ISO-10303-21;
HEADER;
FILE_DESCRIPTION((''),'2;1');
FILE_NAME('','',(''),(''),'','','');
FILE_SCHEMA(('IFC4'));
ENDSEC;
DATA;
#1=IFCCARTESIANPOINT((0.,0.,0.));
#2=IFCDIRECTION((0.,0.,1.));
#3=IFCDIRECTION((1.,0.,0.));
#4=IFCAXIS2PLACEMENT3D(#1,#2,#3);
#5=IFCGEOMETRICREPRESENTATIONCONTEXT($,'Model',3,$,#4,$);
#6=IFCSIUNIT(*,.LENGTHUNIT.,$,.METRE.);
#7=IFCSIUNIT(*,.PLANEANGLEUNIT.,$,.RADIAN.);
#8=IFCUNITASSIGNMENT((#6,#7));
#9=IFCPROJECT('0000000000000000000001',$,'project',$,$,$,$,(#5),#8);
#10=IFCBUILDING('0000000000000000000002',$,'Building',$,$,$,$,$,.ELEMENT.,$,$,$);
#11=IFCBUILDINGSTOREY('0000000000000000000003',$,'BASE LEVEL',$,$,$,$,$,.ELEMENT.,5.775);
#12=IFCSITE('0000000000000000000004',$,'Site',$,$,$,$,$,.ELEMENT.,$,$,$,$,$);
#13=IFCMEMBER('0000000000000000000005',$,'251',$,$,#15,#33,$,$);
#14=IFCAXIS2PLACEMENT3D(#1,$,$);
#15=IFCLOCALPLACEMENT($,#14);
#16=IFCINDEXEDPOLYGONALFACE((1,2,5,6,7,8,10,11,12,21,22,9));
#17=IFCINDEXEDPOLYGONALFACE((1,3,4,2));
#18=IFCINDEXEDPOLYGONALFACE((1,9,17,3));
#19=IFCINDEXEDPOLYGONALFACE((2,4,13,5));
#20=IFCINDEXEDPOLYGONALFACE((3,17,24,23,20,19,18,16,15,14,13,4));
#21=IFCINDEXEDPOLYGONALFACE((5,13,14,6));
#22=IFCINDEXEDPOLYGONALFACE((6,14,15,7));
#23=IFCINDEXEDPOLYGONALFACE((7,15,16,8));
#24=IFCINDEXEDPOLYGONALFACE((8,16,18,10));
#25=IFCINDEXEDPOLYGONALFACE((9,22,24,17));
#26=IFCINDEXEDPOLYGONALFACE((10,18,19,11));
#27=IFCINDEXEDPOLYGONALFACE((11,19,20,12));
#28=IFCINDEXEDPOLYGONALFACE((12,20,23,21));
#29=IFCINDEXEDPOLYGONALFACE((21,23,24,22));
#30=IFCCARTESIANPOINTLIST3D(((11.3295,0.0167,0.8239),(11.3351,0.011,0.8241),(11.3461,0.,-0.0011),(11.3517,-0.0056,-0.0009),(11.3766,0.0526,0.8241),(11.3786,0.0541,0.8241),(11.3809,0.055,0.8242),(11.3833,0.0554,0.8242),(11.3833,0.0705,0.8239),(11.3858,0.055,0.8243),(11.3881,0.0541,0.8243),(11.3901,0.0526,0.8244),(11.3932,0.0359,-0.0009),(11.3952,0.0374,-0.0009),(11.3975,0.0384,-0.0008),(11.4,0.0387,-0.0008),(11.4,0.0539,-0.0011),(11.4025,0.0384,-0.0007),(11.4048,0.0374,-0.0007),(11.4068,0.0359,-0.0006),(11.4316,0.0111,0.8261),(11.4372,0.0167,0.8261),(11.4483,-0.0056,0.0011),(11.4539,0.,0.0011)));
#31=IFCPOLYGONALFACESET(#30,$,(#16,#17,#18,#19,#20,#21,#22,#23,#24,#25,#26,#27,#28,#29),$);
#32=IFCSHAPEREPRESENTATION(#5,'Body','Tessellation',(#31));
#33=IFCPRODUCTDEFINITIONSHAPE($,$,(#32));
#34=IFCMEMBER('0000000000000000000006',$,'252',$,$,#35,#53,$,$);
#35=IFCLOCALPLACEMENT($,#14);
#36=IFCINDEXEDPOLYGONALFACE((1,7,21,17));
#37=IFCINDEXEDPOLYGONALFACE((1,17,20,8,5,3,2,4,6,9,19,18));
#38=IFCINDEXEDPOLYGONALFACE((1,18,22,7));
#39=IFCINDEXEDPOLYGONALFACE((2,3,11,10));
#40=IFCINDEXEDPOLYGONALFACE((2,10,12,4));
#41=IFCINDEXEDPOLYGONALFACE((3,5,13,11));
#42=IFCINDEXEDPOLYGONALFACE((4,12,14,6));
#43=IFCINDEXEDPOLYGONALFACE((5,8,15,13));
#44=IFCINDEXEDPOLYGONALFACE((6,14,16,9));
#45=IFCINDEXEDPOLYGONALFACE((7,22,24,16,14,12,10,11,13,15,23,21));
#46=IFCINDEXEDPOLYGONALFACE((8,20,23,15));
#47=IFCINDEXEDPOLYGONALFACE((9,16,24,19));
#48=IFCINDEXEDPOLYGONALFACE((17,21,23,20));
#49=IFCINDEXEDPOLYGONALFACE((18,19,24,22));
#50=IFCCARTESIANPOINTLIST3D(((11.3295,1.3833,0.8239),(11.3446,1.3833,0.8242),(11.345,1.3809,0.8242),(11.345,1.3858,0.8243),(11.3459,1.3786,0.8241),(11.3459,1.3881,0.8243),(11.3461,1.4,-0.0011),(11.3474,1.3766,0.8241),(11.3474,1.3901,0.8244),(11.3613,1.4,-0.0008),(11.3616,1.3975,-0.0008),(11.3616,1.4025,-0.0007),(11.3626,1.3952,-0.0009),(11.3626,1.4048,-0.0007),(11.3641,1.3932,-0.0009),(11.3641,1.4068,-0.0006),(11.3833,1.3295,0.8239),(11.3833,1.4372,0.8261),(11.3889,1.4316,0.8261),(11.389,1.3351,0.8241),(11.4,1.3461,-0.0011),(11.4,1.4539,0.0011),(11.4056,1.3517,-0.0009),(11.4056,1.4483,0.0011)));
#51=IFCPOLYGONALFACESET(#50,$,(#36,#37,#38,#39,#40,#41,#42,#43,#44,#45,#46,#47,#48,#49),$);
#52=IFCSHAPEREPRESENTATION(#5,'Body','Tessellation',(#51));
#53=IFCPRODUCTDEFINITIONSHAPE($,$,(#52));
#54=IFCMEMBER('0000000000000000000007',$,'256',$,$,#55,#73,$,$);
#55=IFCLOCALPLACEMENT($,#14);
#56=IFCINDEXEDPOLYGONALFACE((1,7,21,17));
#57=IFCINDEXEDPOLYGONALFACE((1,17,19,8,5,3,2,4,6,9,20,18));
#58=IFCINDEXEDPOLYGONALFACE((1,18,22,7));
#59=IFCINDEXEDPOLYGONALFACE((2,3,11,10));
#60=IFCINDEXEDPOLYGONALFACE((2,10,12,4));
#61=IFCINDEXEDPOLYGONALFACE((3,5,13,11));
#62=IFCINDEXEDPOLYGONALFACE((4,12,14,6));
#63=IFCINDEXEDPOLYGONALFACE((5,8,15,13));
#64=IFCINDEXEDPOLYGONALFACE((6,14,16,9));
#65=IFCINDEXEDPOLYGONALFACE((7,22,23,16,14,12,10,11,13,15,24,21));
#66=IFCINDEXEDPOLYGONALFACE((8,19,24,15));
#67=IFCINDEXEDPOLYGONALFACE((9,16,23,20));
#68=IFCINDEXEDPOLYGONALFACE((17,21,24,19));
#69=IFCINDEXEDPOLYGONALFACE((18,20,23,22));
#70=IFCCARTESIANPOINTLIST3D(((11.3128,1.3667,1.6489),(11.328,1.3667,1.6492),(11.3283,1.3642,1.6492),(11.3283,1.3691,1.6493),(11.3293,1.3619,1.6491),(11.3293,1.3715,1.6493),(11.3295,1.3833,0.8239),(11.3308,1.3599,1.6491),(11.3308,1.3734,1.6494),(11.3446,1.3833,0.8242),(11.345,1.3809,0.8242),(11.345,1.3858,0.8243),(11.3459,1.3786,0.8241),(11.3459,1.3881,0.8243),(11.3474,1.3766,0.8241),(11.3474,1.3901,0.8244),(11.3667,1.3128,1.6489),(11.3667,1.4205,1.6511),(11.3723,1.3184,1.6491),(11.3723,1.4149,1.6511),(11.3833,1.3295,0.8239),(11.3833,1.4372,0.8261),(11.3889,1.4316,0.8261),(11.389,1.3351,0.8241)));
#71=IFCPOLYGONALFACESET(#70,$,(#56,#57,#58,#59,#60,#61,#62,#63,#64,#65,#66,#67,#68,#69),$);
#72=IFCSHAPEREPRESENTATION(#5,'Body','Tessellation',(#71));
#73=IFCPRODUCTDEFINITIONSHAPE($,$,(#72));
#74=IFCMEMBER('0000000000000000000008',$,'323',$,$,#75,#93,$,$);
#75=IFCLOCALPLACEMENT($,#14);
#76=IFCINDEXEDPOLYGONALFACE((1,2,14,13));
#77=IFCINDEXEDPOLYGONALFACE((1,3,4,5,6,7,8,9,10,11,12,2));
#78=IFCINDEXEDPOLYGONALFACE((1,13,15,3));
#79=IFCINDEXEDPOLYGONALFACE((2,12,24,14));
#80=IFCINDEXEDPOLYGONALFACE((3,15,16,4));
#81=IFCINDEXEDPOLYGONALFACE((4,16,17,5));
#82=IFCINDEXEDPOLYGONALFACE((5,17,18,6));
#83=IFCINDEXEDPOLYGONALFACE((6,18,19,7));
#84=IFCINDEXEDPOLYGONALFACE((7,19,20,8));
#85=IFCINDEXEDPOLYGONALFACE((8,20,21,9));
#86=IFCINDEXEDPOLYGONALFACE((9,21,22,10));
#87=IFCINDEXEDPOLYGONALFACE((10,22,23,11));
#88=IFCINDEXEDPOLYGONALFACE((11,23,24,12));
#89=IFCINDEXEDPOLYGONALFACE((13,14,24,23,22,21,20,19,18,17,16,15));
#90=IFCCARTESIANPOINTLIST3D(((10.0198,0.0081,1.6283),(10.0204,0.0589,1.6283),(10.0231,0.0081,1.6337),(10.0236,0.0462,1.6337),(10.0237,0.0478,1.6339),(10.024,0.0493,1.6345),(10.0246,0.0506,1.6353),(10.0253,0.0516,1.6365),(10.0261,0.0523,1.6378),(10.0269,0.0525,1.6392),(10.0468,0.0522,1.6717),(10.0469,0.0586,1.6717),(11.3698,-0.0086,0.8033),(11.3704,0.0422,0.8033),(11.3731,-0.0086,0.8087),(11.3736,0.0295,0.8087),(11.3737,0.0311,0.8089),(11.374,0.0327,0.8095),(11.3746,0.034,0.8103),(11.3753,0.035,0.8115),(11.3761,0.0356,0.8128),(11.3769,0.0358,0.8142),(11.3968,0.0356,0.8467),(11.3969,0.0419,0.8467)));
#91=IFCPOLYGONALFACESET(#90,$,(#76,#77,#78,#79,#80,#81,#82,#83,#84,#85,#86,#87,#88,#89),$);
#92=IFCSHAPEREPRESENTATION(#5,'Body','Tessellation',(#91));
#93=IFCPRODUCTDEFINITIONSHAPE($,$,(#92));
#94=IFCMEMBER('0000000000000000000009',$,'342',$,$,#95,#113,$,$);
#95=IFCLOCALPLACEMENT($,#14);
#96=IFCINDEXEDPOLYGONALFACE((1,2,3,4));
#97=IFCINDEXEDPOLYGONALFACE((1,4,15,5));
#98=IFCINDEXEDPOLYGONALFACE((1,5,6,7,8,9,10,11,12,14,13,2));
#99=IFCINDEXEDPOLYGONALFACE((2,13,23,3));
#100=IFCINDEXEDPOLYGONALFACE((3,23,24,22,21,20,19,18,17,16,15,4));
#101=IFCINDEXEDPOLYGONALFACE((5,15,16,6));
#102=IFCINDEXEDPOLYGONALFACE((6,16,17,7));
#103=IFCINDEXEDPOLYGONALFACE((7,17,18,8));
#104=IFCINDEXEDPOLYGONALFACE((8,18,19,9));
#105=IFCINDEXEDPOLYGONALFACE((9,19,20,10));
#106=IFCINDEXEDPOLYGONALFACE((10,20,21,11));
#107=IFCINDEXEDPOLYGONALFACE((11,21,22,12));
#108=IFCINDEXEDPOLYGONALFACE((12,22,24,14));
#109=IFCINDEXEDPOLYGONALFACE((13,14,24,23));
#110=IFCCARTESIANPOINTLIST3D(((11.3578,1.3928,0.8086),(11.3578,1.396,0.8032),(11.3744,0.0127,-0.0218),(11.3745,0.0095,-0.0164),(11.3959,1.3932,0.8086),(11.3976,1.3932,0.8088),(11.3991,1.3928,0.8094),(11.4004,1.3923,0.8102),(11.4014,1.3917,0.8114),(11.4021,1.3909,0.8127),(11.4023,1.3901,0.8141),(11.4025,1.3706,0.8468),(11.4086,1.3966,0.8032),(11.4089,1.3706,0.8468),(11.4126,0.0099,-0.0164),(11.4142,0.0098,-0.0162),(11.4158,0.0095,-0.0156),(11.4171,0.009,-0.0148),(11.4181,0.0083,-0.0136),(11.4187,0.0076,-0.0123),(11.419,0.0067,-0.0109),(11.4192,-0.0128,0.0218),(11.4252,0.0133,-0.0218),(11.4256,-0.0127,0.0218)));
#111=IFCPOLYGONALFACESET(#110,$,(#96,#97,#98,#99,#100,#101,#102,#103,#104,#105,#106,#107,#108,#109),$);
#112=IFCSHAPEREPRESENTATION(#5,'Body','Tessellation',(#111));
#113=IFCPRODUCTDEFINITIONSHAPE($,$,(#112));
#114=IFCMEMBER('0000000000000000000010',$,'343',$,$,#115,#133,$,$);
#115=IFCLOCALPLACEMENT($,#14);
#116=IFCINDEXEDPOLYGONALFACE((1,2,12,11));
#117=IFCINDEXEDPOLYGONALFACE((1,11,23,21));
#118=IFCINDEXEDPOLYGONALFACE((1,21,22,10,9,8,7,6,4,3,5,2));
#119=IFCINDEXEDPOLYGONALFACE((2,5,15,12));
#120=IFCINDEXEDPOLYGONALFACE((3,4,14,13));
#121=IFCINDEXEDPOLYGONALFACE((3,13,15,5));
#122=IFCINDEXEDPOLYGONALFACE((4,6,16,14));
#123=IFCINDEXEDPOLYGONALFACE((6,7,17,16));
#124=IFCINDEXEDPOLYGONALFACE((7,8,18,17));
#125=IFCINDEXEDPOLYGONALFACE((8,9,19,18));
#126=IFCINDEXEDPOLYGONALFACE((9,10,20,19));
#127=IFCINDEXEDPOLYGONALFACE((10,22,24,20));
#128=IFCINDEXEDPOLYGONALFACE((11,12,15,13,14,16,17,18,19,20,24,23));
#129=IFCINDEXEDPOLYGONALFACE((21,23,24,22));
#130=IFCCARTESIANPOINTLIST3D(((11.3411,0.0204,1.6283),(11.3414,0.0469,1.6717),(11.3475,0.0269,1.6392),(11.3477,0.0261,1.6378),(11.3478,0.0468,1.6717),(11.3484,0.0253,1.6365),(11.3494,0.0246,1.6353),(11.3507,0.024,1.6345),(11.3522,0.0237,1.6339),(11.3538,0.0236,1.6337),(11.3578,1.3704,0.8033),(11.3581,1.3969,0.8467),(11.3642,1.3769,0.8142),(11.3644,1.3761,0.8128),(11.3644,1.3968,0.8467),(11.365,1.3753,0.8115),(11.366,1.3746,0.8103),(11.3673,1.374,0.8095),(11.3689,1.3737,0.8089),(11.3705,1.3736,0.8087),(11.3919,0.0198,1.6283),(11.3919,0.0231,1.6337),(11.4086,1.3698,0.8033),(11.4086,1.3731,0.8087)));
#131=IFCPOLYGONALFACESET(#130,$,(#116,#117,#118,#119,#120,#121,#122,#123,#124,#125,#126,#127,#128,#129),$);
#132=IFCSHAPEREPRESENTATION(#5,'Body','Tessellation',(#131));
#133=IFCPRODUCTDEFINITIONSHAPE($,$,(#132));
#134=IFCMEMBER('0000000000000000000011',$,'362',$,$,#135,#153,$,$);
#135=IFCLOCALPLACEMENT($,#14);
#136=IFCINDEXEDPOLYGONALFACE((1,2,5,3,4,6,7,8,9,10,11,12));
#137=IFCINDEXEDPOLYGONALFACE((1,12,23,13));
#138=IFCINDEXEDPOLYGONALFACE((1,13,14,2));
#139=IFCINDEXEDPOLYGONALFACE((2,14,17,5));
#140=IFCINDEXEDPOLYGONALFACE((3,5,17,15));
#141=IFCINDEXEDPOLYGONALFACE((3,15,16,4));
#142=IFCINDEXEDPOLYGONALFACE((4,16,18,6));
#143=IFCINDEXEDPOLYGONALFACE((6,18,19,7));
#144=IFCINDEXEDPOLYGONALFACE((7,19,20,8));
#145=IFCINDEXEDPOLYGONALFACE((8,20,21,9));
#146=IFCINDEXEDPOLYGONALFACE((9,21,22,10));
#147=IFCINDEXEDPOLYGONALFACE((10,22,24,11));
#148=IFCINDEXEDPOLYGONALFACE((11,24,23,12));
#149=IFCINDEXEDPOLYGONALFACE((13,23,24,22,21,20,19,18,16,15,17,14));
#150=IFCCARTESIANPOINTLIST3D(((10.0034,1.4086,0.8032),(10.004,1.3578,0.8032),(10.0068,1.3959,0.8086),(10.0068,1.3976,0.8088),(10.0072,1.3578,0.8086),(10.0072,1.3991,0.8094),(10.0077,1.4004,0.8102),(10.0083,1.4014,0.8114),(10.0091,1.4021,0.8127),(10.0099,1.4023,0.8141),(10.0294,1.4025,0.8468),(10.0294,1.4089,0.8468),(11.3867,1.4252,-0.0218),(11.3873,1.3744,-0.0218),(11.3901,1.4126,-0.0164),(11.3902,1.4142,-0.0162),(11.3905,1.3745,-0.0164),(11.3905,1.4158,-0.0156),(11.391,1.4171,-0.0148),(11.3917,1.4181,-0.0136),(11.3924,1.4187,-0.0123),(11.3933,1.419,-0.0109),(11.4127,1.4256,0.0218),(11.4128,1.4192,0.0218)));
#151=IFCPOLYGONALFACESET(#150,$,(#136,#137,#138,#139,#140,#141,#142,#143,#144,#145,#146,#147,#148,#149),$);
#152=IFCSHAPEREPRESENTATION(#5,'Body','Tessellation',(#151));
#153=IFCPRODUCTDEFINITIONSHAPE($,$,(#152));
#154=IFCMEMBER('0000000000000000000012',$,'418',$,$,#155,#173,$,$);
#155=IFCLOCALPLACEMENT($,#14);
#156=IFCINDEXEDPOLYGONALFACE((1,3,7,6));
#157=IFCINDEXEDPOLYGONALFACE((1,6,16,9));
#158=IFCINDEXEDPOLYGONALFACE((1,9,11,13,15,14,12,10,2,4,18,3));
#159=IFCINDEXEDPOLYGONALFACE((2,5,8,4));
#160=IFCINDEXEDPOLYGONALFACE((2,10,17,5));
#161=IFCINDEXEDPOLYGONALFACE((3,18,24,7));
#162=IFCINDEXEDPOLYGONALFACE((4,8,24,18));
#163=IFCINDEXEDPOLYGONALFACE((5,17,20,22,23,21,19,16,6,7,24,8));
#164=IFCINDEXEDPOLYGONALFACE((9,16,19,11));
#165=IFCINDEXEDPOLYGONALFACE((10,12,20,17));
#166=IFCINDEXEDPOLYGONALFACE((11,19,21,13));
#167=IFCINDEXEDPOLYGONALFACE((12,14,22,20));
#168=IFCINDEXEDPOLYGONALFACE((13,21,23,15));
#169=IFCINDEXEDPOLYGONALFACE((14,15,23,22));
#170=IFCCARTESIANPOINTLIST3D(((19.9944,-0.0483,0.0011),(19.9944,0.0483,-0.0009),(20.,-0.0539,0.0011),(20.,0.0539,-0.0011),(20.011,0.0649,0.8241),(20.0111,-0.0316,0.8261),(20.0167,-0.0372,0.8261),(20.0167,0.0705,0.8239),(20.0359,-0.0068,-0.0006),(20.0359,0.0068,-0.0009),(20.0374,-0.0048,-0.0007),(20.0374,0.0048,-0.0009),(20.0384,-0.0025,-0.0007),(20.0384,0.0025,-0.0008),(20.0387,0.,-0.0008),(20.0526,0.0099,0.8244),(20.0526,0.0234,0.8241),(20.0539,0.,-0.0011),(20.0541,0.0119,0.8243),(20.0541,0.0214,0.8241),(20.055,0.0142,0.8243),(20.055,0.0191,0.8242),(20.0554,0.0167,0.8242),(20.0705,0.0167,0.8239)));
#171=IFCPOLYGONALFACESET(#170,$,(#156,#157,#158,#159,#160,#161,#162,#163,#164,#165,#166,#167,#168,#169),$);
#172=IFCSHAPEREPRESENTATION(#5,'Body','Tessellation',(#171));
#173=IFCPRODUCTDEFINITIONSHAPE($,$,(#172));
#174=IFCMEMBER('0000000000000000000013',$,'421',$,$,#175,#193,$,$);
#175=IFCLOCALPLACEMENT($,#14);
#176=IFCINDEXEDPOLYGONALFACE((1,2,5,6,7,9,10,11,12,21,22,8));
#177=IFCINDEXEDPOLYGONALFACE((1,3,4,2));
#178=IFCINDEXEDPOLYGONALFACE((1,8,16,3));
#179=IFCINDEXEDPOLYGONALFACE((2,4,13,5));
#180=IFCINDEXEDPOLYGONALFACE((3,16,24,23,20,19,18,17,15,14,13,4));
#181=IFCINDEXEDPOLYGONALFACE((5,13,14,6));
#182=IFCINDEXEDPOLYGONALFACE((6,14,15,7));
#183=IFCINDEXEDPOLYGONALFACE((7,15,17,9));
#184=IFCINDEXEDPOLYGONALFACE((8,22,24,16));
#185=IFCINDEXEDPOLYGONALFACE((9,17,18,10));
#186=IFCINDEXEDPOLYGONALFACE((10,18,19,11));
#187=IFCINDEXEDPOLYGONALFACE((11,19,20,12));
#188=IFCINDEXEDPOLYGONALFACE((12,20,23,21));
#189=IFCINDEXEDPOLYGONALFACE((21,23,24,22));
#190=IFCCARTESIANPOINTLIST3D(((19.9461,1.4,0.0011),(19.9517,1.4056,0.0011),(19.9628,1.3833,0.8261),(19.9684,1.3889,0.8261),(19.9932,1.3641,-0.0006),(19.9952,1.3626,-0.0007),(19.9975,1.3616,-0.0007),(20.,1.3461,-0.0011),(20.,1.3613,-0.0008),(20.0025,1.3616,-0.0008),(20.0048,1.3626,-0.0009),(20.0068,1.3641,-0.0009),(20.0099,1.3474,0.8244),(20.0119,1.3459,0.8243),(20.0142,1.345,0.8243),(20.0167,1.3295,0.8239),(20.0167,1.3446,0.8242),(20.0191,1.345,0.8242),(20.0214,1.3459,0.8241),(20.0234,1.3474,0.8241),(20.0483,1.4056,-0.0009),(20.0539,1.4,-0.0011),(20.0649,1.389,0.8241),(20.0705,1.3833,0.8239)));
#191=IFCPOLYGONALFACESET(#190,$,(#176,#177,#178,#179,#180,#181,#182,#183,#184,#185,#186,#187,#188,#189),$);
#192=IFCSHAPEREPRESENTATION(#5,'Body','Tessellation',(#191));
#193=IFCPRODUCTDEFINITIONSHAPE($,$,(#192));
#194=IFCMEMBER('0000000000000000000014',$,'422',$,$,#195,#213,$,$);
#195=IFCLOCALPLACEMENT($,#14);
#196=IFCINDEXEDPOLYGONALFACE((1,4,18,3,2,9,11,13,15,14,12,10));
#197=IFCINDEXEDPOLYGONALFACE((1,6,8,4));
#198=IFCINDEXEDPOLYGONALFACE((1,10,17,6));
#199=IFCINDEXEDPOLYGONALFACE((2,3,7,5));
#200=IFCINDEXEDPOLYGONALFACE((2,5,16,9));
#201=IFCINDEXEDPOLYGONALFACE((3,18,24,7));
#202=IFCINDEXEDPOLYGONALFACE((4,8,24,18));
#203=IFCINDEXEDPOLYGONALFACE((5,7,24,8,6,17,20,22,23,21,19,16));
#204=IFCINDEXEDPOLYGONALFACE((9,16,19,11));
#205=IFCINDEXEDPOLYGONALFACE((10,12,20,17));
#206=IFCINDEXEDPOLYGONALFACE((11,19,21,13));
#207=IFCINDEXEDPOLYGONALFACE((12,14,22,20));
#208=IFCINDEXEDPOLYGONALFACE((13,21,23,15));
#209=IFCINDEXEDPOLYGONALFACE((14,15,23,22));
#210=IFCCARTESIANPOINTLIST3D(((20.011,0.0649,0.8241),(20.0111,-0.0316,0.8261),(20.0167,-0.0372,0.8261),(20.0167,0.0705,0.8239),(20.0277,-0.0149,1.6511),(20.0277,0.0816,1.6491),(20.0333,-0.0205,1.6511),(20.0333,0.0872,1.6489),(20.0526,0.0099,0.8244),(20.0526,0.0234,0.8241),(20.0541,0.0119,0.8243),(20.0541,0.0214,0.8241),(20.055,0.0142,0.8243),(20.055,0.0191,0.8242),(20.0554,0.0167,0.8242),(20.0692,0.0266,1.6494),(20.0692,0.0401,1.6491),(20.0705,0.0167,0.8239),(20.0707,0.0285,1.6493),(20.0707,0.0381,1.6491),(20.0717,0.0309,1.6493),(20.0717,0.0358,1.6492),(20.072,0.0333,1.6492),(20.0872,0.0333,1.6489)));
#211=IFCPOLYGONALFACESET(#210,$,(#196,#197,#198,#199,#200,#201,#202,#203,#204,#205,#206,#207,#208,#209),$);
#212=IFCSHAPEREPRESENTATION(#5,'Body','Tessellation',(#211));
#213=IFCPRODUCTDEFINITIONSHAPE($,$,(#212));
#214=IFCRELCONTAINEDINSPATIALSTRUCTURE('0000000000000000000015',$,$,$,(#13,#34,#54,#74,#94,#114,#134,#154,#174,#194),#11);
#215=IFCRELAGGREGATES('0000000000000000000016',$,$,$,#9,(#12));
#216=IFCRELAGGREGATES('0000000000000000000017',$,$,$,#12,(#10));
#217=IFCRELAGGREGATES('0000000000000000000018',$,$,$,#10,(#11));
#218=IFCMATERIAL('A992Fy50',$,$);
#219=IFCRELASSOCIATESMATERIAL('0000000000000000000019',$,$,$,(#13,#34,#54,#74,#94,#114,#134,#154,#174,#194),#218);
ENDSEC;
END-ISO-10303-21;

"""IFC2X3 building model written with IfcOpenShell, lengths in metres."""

from ifc_helpers import new_model, si_unit, frame, origin_with_axes, origin_2d_with_axis, place, context, project, spatial, l_section, extrude, material, element, save


model = new_model("IFC2X3")

# Units and contexts
model_context = context("Model", 3, world=origin_with_axes())
ifc_project = project(units=[si_unit("LENGTHUNIT", "METRE"), si_unit("PLANEANGLEUNIT", "RADIAN")], contexts=[model_context])

# Site, building, storey
site = spatial("IfcSite", under=ifc_project, Name="Site", CompositionType="ELEMENT")
building = spatial("IfcBuilding", under=site, Name="Building", CompositionType="ELEMENT")
storey = spatial("IfcBuildingStorey", under=building, Name="BASE LEVEL", CompositionType="ELEMENT", Elevation=5.775)

# Members
ifc_material = material(Name="A992Fy50")
for number, where, z_axis, x_axis, name in (
    (1, (11.4, 0.0, 0.0), (-0.020194, 0.020194, 0.999592), (-0.707107, -0.707107, 0.0), "251"),
    (2, (11.4, 1.4, 0.0), (-0.020194, -0.020194, 0.999592), (0.707107, -0.707107, 0.0), "252"),
    (3, (11.3833, 1.3833, 0.825), (-0.020194, -0.020194, 0.999592), (0.707107, -0.707107, 0.0), "256"),
):
    element("IfcMember", number, at=place(None, frame(where, z_axis=z_axis, x_axis=x_axis)), inside=storey, material=ifc_material, Name=name, context=model_context, shape_type="SweptSolid", body=[
        extrude(l_section(Depth=0.0762, Width=0.0762, Thickness=0.0079, FilletRadius=0.0096, at=origin_2d_with_axis()), origin_with_axes(), (0.0, 0.0, 1.0), 0.8253),
    ])
member_1_placement = place(None, frame((11.3833, 0.0167, 0.825), z_axis=(-0.853234, 0.010534, 0.521421), x_axis=(-0.012345, -0.999924, 0.0)))
element("IfcMember", 4, at=member_1_placement, inside=storey, material=ifc_material, Name="323", context=model_context, shape_type="SweptSolid", body=[
    extrude(l_section(Depth=0.0508, Width=0.0508, Thickness=0.0063, FilletRadius=0.0063, at=origin_2d_with_axis()), origin_with_axes(), (0.0, 0.0, 1.0), 1.5822),
])
member_2_placement = place(None, frame((11.4, 0.0, 0.0), z_axis=(-0.010347, 0.858813, 0.512184), x_axis=(-0.999927, -0.012047, 0.0)))
element("IfcMember", 5, at=member_2_placement, inside=storey, material=ifc_material, Name="342", context=model_context, shape_type="SweptSolid", body=[
    extrude(l_section(Depth=0.0508, Width=0.0508, Thickness=0.0063, FilletRadius=0.0063, at=origin_2d_with_axis()), origin_with_axes(), (0.0, 0.0, 1.0), 1.6107),
])
member_3_placement = place(None, frame((11.3833, 1.3833, 0.825), z_axis=(-0.010534, -0.853234, 0.521421), x_axis=(0.999924, -0.012345, 0.0)))
element("IfcMember", 6, at=member_3_placement, inside=storey, material=ifc_material, Name="343", context=model_context, shape_type="SweptSolid", body=[
    extrude(l_section(Depth=0.0508, Width=0.0508, Thickness=0.0063, FilletRadius=0.0063, at=origin_2d_with_axis()), origin_with_axes(), (0.0, 0.0, 1.0), 1.5822),
])
member_4_placement = place(None, frame((11.4, 1.4, 0.0), z_axis=(-0.858813, -0.010347, 0.512184), x_axis=(0.012047, -0.999927, 0.0)))
element("IfcMember", 7, at=member_4_placement, inside=storey, material=ifc_material, Name="362", context=model_context, shape_type="SweptSolid", body=[
    extrude(l_section(Depth=0.0508, Width=0.0508, Thickness=0.0063, FilletRadius=0.0063, at=origin_2d_with_axis()), origin_with_axes(), (0.0, 0.0, 1.0), 1.6107),
])
for number, where, z_axis, x_axis, name in (
    (8, (20.0, 0.0, 0.0), (0.020194, 0.020194, 0.999592), (-0.707107, 0.707107, 0.0), "418"),
    (9, (20.0, 1.4, 0.0), (0.020194, -0.020194, 0.999592), (0.707107, 0.707107, 0.0), "421"),
    (10, (20.0167, 0.0167, 0.825), (0.020194, 0.020194, 0.999592), (-0.707107, 0.707107, 0.0), "422"),
):
    element("IfcMember", number, at=place(None, frame(where, z_axis=z_axis, x_axis=x_axis)), inside=storey, material=ifc_material, Name=name, context=model_context, shape_type="SweptSolid", body=[
        extrude(l_section(Depth=0.0762, Width=0.0762, Thickness=0.0079, FilletRadius=0.0096, at=origin_2d_with_axis()), origin_with_axes(), (0.0, 0.0, 1.0), 0.8253),
    ])

save(model, "model.ifc")
